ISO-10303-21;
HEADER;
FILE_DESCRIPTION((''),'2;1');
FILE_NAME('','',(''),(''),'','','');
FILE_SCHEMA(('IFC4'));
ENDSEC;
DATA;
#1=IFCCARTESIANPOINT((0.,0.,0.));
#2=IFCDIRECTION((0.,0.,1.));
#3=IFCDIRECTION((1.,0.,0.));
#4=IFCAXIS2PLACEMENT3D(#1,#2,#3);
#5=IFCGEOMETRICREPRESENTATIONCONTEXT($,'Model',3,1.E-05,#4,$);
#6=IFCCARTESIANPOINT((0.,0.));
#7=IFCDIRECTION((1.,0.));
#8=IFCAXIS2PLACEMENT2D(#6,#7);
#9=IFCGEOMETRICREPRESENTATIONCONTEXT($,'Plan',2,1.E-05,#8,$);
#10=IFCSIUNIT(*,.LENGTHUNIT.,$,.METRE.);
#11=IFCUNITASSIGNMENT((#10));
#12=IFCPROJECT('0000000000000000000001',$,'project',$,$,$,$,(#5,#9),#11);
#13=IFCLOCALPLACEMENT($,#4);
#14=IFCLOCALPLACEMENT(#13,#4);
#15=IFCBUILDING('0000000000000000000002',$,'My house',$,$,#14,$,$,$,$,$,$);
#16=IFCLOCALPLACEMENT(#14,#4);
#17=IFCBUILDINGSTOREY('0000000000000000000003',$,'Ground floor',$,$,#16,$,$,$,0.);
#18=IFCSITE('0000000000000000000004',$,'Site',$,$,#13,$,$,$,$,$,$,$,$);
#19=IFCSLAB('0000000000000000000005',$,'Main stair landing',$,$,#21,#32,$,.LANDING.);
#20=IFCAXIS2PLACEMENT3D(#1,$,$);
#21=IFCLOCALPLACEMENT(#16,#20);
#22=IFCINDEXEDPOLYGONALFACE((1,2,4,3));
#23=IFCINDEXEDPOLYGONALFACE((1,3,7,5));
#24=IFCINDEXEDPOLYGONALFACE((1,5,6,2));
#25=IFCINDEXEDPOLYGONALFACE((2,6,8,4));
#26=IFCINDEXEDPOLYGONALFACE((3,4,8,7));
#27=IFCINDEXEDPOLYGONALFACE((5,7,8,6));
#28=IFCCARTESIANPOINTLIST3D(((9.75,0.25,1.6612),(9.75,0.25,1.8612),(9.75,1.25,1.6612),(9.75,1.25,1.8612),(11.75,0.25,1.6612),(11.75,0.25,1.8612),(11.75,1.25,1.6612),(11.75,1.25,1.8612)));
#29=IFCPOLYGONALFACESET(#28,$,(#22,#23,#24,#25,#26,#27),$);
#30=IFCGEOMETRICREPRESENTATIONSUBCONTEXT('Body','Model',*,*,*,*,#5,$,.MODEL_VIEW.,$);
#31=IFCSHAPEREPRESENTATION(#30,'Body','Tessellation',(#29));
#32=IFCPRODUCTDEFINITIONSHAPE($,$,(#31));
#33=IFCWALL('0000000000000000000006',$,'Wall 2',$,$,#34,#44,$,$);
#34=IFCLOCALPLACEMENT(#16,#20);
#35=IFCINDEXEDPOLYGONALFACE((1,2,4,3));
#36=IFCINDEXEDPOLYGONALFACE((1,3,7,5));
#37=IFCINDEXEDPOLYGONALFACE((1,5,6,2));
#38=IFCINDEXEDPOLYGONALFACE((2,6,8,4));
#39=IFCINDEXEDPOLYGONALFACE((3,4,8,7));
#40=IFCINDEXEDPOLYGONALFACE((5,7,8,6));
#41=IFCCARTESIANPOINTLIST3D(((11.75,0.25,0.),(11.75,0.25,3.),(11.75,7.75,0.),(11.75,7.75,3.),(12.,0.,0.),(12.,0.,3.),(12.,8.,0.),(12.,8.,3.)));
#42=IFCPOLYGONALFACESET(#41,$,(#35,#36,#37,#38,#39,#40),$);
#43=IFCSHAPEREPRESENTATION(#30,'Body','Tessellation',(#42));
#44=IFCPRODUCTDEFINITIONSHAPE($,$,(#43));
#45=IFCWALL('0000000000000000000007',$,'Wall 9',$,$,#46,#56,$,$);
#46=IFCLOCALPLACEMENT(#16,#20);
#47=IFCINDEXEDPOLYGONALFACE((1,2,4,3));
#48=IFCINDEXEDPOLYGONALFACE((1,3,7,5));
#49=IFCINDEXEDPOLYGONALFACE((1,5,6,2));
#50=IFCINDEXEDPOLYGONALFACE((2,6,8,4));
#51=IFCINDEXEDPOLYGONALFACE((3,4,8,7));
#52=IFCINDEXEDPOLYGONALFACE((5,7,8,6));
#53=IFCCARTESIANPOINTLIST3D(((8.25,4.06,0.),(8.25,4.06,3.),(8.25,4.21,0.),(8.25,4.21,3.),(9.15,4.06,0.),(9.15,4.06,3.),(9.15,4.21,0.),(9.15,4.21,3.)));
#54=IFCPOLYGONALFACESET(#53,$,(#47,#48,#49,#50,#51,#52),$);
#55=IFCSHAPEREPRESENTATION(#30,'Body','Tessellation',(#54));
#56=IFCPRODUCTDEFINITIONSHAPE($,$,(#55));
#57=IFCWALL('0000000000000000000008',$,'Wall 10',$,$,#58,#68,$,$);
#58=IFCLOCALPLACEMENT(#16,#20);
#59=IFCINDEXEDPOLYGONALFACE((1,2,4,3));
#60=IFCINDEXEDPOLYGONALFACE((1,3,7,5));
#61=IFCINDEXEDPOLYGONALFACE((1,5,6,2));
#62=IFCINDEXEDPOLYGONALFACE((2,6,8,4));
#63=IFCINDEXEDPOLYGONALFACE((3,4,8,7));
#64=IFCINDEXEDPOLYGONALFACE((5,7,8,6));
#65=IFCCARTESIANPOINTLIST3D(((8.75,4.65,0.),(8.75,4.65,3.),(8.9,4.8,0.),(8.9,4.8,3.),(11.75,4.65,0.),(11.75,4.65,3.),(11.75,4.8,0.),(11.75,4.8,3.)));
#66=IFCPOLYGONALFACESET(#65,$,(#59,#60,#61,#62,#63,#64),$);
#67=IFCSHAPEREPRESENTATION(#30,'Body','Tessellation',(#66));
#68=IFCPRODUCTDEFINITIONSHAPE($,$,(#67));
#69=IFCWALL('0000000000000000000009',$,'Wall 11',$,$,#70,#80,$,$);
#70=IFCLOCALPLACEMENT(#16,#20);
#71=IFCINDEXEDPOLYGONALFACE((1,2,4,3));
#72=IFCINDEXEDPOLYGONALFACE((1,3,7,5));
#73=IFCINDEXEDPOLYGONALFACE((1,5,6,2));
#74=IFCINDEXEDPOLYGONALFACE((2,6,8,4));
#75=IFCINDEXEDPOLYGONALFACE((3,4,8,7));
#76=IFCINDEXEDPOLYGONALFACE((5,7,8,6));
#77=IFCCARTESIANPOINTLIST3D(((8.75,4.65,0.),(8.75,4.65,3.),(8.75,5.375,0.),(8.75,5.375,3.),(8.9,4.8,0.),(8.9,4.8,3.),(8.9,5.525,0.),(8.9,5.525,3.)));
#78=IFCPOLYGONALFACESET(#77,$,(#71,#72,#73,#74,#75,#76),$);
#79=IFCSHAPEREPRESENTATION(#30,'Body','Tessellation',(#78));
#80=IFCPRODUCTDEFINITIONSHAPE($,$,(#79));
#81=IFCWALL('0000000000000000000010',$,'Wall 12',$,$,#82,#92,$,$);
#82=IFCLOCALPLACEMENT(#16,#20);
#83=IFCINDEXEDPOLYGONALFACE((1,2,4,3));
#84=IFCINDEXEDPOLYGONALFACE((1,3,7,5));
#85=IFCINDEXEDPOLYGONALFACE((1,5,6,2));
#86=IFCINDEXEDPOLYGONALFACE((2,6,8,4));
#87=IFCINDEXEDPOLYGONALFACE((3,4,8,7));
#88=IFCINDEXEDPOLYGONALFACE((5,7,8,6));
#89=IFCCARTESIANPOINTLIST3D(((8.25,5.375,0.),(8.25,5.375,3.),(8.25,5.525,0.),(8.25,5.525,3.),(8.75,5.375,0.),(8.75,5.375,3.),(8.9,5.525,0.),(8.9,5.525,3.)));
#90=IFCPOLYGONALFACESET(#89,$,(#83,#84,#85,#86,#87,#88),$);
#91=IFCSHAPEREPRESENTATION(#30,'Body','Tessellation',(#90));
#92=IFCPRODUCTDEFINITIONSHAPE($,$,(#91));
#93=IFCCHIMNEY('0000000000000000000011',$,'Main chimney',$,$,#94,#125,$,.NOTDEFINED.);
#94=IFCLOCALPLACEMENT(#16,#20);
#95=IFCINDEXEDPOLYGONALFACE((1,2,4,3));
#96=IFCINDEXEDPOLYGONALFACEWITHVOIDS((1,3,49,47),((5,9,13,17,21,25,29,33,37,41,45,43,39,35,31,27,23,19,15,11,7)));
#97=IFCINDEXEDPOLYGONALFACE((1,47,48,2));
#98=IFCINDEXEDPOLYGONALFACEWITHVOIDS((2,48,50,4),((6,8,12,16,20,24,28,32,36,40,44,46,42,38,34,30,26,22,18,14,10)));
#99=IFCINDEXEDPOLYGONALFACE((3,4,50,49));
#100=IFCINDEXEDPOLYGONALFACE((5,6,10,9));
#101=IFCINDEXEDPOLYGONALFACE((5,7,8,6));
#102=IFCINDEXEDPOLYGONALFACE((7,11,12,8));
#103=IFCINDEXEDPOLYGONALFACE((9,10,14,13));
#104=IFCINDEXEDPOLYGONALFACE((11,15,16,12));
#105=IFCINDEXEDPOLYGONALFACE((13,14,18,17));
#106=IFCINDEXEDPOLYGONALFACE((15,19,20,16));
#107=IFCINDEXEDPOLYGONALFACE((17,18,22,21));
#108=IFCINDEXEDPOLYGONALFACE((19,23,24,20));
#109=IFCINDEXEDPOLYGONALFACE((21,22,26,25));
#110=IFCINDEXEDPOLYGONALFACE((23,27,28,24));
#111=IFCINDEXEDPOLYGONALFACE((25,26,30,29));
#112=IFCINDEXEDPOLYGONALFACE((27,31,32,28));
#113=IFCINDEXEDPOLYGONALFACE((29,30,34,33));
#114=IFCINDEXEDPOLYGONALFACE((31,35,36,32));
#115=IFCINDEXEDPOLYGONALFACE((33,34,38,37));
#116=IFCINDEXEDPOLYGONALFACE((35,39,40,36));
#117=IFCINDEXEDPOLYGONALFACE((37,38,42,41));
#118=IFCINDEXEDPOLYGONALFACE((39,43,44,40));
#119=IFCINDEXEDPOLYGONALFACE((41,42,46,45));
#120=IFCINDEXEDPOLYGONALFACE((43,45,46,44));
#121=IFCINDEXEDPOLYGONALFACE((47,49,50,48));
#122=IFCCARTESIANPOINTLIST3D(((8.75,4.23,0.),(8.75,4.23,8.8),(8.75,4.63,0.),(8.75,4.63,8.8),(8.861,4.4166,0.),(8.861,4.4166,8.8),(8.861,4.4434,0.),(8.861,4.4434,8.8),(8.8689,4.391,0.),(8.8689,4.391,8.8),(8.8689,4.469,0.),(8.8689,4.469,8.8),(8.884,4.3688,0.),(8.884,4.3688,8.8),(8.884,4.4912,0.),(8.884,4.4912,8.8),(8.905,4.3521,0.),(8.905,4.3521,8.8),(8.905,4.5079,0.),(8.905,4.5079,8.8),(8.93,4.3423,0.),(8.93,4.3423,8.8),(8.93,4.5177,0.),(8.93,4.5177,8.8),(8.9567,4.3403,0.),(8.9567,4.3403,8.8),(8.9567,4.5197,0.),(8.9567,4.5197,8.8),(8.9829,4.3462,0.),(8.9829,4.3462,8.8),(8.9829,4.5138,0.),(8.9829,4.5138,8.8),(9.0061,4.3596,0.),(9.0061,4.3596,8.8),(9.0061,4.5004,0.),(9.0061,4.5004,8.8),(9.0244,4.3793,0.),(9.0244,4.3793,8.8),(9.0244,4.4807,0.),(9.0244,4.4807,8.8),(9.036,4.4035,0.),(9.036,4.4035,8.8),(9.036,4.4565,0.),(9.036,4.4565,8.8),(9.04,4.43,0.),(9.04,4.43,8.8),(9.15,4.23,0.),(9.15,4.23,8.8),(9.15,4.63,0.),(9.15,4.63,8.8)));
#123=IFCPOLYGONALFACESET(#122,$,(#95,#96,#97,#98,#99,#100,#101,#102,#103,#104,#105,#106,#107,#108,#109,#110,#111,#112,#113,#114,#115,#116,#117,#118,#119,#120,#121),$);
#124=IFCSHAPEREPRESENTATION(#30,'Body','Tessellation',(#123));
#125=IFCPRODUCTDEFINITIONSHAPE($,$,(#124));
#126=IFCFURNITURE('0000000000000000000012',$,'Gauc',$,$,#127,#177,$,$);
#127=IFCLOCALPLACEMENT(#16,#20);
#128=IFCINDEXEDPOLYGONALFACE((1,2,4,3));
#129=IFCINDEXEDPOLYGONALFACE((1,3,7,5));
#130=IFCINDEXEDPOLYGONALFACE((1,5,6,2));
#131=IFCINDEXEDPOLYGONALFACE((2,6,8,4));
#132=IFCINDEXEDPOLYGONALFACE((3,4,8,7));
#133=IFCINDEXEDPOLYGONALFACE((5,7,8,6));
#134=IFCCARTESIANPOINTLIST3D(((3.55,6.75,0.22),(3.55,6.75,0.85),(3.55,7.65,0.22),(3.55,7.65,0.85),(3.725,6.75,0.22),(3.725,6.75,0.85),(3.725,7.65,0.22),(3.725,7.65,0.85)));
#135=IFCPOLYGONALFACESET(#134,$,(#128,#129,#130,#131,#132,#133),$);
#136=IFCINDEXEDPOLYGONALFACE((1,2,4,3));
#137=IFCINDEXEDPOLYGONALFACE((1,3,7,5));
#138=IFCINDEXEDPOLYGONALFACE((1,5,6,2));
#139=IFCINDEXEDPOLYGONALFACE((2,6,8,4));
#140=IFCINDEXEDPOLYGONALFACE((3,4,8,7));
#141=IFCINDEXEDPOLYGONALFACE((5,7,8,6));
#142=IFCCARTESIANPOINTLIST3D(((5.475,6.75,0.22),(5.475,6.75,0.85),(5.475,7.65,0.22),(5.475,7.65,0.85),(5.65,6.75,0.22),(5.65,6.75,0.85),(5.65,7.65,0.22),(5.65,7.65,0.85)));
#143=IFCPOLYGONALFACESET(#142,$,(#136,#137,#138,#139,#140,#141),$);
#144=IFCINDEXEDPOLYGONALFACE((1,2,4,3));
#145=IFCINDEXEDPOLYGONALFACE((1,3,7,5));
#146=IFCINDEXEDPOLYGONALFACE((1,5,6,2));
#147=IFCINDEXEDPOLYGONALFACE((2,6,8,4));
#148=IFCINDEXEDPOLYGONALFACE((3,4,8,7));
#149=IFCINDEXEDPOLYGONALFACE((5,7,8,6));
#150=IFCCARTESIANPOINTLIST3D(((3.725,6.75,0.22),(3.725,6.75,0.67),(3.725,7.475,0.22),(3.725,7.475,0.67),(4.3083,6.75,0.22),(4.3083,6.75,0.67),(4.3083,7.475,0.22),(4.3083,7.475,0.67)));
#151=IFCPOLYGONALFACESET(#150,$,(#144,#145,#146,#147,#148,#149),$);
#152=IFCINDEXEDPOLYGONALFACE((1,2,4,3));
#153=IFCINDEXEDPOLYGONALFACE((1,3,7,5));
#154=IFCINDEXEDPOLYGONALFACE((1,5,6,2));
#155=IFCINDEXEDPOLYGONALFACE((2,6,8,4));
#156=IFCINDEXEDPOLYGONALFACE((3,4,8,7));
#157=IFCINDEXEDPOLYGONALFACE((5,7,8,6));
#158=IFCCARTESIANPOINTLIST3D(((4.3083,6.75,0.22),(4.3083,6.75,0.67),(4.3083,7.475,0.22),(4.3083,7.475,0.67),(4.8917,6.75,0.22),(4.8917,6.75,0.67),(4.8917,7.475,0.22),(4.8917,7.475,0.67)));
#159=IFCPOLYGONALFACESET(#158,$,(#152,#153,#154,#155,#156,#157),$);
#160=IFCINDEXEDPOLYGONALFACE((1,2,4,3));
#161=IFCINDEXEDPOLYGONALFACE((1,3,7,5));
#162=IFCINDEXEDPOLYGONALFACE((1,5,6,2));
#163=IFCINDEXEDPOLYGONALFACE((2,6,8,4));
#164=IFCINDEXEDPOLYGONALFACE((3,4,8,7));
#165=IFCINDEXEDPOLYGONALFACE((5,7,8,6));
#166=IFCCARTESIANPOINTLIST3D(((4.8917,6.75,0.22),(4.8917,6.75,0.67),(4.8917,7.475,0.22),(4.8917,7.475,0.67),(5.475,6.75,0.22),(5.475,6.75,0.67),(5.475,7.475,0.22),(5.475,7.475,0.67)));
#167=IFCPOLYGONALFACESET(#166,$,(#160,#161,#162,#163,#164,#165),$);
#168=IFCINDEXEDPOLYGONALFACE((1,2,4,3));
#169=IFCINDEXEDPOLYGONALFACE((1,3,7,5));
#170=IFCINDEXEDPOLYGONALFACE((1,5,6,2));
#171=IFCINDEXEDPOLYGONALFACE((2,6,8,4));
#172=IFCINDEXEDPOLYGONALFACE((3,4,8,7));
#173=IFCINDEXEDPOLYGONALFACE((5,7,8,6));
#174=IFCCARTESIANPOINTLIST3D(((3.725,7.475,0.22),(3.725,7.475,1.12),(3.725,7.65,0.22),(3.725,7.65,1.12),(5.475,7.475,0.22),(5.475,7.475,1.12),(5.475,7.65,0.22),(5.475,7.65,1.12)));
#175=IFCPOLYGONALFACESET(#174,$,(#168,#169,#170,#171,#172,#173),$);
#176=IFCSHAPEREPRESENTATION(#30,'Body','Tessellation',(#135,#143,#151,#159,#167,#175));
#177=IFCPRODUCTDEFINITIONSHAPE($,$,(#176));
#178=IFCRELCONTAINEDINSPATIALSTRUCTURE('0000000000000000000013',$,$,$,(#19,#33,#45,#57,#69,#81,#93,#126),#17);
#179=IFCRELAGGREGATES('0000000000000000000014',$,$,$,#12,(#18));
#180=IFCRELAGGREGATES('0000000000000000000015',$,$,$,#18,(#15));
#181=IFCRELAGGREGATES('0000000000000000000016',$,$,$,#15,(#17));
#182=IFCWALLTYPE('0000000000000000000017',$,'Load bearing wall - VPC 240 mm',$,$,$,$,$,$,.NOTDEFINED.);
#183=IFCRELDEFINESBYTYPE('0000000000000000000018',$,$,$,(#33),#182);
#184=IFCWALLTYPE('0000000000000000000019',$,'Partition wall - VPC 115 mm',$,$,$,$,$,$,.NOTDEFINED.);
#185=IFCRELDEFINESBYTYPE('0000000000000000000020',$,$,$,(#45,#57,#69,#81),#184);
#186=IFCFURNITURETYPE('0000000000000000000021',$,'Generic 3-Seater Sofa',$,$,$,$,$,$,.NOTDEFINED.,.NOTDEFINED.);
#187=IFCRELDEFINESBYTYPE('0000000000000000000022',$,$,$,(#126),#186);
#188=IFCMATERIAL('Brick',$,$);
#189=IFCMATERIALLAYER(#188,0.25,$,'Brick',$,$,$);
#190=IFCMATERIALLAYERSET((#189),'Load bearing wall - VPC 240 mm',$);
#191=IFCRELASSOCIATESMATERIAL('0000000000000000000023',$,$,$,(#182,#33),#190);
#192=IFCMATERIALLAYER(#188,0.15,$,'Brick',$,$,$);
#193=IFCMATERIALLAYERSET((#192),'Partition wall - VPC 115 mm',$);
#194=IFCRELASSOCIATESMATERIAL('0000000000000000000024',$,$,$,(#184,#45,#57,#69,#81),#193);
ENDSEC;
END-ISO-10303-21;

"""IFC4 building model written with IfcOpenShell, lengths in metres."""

from ifc_helpers import new_model, entity, si_unit, frame, origin_with_axes, origin_2d_with_axis, place, context, subcontext, project, spatial, line, indexed_curve, circle_curve, outline, extrude, shape, source, transform, mapped, material, layer, layer_set, layer_usage, type_object, type_shapes, element, save


model = new_model("IFC4")

# Units and contexts
model_context = context("Model", 3, precision=1e-05, world=origin_with_axes())
plan_context = context("Plan", 2, precision=1e-05, world=origin_2d_with_axis())
body_context_1 = subcontext(model_context, "Body", "Model", "MODEL_VIEW")
body_context_2 = subcontext(plan_context, "Body", "Plan", "PLAN_VIEW")
ifc_project = project(units=[si_unit("LENGTHUNIT", "METRE")], contexts=[model_context, plan_context])

# Site, building, storey
site_placement = place(None, origin_with_axes())
site = spatial("IfcSite", under=ifc_project, at=site_placement, Name="Site")
building_placement = place(site_placement, origin_with_axes())
building = spatial("IfcBuilding", under=site, at=building_placement, Name="My house")
storey_placement = place(building_placement, origin_with_axes())
storey = spatial("IfcBuildingStorey", under=building, at=storey_placement, Name="Ground floor", Elevation=0.0)

# Slab
slab_placement = place(storey_placement, frame((9.75, 0.25, 1.6612), z_axis=(0.0, 0.0, 1.0), x_axis=(1.0, 0.0, 0.0)))
element("IfcSlab", 1, at=slab_placement, inside=storey, Name="Main stair landing", PredefinedType="LANDING", context=body_context_1, shape_type="SweptSolid", body=[
    extrude(outline(indexed_curve([(0.0, 0.0), (2.0, 0.0), (2.0, 1.0), (0.0, 1.0)])), None, (0.0, 0.0, 1.0), 0.2),
])

# Wall
ifc_material = material(Name="Brick")
ifc_layer_1 = layer(ifc_material, 0.25, Name="Brick")
ifc_layer_set_1 = layer_set([ifc_layer_1], Name="Load bearing wall - VPC 240 mm")
ifc_layer_usage_1 = layer_usage(ifc_layer_set_1, "AXIS2", "NEGATIVE", 0.25)
wall_type_1 = type_object("IfcWallType", Name="Load bearing wall - VPC 240 mm", PredefinedType="NOTDEFINED", material=ifc_layer_set_1)
wall_1_placement = place(storey_placement, frame((12.0, 0.0, 0.0), z_axis=(0.0, 0.0, 1.0), x_axis=(0.0, 1.0, 0.0)))
element("IfcWall", 2, at=wall_1_placement, inside=storey, type_object=wall_type_1, material=ifc_layer_usage_1, Name="Wall 2", context=body_context_1, shape_type="SweptSolid", body=[
    extrude(outline(indexed_curve([(0.0, 0.0), (0.25, 0.25), (7.75, 0.25), (8.0, 0.0)], segments=[line(1, 2, 3, 4, 1)])), origin_with_axes(), (0.0, 0.0, 1.0), 3.0),
])

# Walls
ifc_layer_2 = layer(ifc_material, 0.15, Name="Brick")
ifc_layer_set_2 = layer_set([ifc_layer_2], Name="Partition wall - VPC 115 mm")
ifc_layer_usage_2 = layer_usage(ifc_layer_set_2, "AXIS2", "NEGATIVE", 0.15)
wall_type_2 = type_object("IfcWallType", Name="Partition wall - VPC 115 mm", PredefinedType="NOTDEFINED", material=ifc_layer_set_2)
wall_2_placement = place(storey_placement, frame((9.15, 4.21, 0.0), z_axis=(0.0, 0.0, 1.0), x_axis=(-1.0, 0.0, 0.0)))
element("IfcWall", 3, at=wall_2_placement, inside=storey, type_object=wall_type_2, material=ifc_layer_usage_2, Name="Wall 9", context=body_context_1, shape_type="SweptSolid", body=[
    extrude(outline(indexed_curve([(0.0, 0.0), (0.0, 0.15), (0.9, 0.15), (0.9, 0.0), (0.0, 0.0)], self_intersect=False)), origin_with_axes(), (0.0, 0.0, 1.0), 3.0),
])
ifc_layer_usage_3 = layer_usage(ifc_layer_set_2, "AXIS2", "NEGATIVE", 0.15)
wall_3_placement = place(storey_placement, frame((8.75, 4.65, 0.0), z_axis=(0.0, 0.0, 1.0), x_axis=(1.0, 0.0, 0.0)))
element("IfcWall", 4, at=wall_3_placement, inside=storey, type_object=wall_type_2, material=ifc_layer_usage_3, Name="Wall 10", context=body_context_1, shape_type="SweptSolid", body=[
    extrude(outline(indexed_curve([(0.0, 0.0), (0.15, 0.15), (3.0, 0.15), (3.0, 0.0)], segments=[line(1, 2, 3, 4, 1)])), origin_with_axes(), (0.0, 0.0, 1.0), 3.0),
])
ifc_layer_usage_4 = layer_usage(ifc_layer_set_2, "AXIS2", "NEGATIVE", 0.15)
wall_4_placement = place(storey_placement, frame((8.75, 5.375, 0.0), z_axis=(0.0, 0.0, 1.0), x_axis=(0.0, -1.0, 0.0)))
element("IfcWall", 5, at=wall_4_placement, inside=storey, type_object=wall_type_2, material=ifc_layer_usage_4, Name="Wall 11", context=body_context_1, shape_type="SweptSolid", body=[
    extrude(outline(indexed_curve([(0.0, 0.0), (-0.15, 0.15), (0.575, 0.15), (0.725, 0.0)], segments=[line(1, 2, 3, 4, 1)])), origin_with_axes(), (0.0, 0.0, 1.0), 3.0),
])
ifc_layer_usage_5 = layer_usage(ifc_layer_set_2, "AXIS2", "NEGATIVE", 0.15)
wall_5_placement = place(storey_placement, frame((8.25, 5.375, 0.0), z_axis=(0.0, 0.0, 1.0), x_axis=(1.0, 0.0, 0.0)))
element("IfcWall", 6, at=wall_5_placement, inside=storey, type_object=wall_type_2, material=ifc_layer_usage_5, Name="Wall 12", context=body_context_1, shape_type="SweptSolid", body=[
    extrude(outline(indexed_curve([(0.0, 0.0), (0.0, 0.15), (0.65, 0.15), (0.5, 0.0)], segments=[line(1, 2, 3, 4, 1)])), origin_with_axes(), (0.0, 0.0, 1.0), 3.0),
])

# Chimney
chimney_placement = place(storey_placement, frame((8.95, 4.43, 0.0), z_axis=(0.0, 0.0, 1.0), x_axis=(1.0, 0.0, 0.0)))
element("IfcChimney", 7, at=chimney_placement, inside=storey, Name="Main chimney", PredefinedType="NOTDEFINED", context=body_context_1, shape_type="SweptSolid", body=[
    extrude(outline(indexed_curve([(-0.2, -0.2), (0.2, -0.2), (0.2, 0.2), (-0.2, 0.2), (-0.2, -0.2)], self_intersect=False), holes=[circle_curve(origin_2d_with_axis(), 0.09)]), origin_with_axes(), (0.0, 0.0, 1.0), 8.8),
])

# Furniture
furniture_type_1 = type_object("IfcFurnitureType", Name="Generic 3-Seater Sofa", AssemblyPlace="NOTDEFINED", PredefinedType="NOTDEFINED")
shared_shape_1 = source(origin_with_axes(), body_context_1, "Body", "SweptSolid", [
    extrude(outline(indexed_curve([(0.0, 0.0), (0.175, 0.0), (0.175, 0.9), (0.0, 0.9)], segments=[line(1, 2, 3, 4, 1)])), frame((-1.05, -0.9, 0.0), z_axis=(0.0, 0.0, 1.0), x_axis=(1.0, 0.0, 0.0)), (0.0, 0.0, 1.0), 0.63),
    extrude(outline(indexed_curve([(0.0, 0.0), (0.175, 0.0), (0.175, 0.9), (0.0, 0.9)], segments=[line(1, 2, 3, 4, 1)])), frame((0.875, -0.9, 0.0), z_axis=(0.0, 0.0, 1.0), x_axis=(1.0, 0.0, 0.0)), (0.0, 0.0, 1.0), 0.63),
    extrude(outline(indexed_curve([(0.175, 0.0), (0.7583, 0.0), (0.7583, 0.725), (0.175, 0.725)], segments=[line(1, 2, 3, 4, 1)])), frame((-1.05, -0.9, 0.0), z_axis=(0.0, 0.0, 1.0), x_axis=(1.0, 0.0, 0.0)), (0.0, 0.0, 1.0), 0.45),
    extrude(outline(indexed_curve([(0.7583, 0.0), (1.3417, 0.0), (1.3417, 0.725), (0.7583, 0.725)], segments=[line(1, 2, 3, 4, 1)])), frame((-1.05, -0.9, 0.0), z_axis=(0.0, 0.0, 1.0), x_axis=(1.0, 0.0, 0.0)), (0.0, 0.0, 1.0), 0.45),
    extrude(outline(indexed_curve([(1.3417, 0.0), (1.925, 0.0), (1.925, 0.725), (1.3417, 0.725)], segments=[line(1, 2, 3, 4, 1)])), frame((-1.05, -0.9, 0.0), z_axis=(0.0, 0.0, 1.0), x_axis=(1.0, 0.0, 0.0)), (0.0, 0.0, 1.0), 0.45),
    extrude(outline(indexed_curve([(0.175, 0.725), (1.925, 0.725), (1.925, 0.9), (0.175, 0.9)], segments=[line(1, 2, 3, 4, 1)])), frame((-1.05, -0.9, 0.0), z_axis=(0.0, 0.0, 1.0), x_axis=(1.0, 0.0, 0.0)), (0.0, 0.0, 1.0), 0.9),
])
shared_shape_2 = source(origin_with_axes(), body_context_2, "Body", "Curve2D", [
    entity("IfcIndexedPolyCurve", entity("IfcCartesianPointList2D", [[-1.05, -0.9], [-0.875, -0.9], [-0.875, 0.0], [-1.05, 0.0]]), [entity("IfcLineIndex", [1, 2, 3, 4, 1])]),
    entity("IfcIndexedPolyCurve", entity("IfcCartesianPointList2D", [[0.875, -0.9], [1.05, -0.9], [1.05, 0.0], [0.875, 0.0]]), [entity("IfcLineIndex", [1, 2, 3, 4, 1])]),
    entity("IfcIndexedPolyCurve", entity("IfcCartesianPointList2D", [[-0.875, -0.9], [-0.2917, -0.9], [-0.2917, -0.175], [-0.875, -0.175]]), [entity("IfcLineIndex", [1, 2, 3, 4, 1])]),
    entity("IfcIndexedPolyCurve", entity("IfcCartesianPointList2D", [[-0.2917, -0.9], [0.2917, -0.9], [0.2917, -0.175], [-0.2917, -0.175]]), [entity("IfcLineIndex", [1, 2, 3, 4, 1])]),
    entity("IfcIndexedPolyCurve", entity("IfcCartesianPointList2D", [[0.2917, -0.9], [0.875, -0.9], [0.875, -0.175], [0.2917, -0.175]]), [entity("IfcLineIndex", [1, 2, 3, 4, 1])]),
    entity("IfcIndexedPolyCurve", entity("IfcCartesianPointList2D", [[-0.875, -0.175], [0.875, -0.175], [0.875, 0.0], [-0.875, 0.0]]), [entity("IfcLineIndex", [1, 2, 3, 4, 1])]),
])
type_shapes(furniture_type_1, [shared_shape_1, shared_shape_2])
furniture_1_placement = place(storey_placement, frame((4.6, 7.65, 0.22), z_axis=(0.0, 0.0, 1.0), x_axis=(1.0, 0.0, 0.0)))
element("IfcFurniture", 8, at=furniture_1_placement, inside=storey, type_object=furniture_type_1, Name="Gauc", shapes=[
    shape(body_context_1, "Body", "MappedRepresentation", [mapped(shared_shape_1, transform((0.0, 0.0, 0.0), x_axis=(1.0, 0.0, 0.0), y_axis=(0.0, 1.0, 0.0), z_axis=(0.0, 0.0, 1.0), scale=1.0))]),
    shape(body_context_2, "Body", "MappedRepresentation", [mapped(shared_shape_2, transform((0.0, 0.0, 0.0), x_axis=(1.0, 0.0, 0.0), y_axis=(0.0, 1.0, 0.0), z_axis=(0.0, 0.0, 1.0), scale=1.0))]),
])

save(model, "model.ifc")
